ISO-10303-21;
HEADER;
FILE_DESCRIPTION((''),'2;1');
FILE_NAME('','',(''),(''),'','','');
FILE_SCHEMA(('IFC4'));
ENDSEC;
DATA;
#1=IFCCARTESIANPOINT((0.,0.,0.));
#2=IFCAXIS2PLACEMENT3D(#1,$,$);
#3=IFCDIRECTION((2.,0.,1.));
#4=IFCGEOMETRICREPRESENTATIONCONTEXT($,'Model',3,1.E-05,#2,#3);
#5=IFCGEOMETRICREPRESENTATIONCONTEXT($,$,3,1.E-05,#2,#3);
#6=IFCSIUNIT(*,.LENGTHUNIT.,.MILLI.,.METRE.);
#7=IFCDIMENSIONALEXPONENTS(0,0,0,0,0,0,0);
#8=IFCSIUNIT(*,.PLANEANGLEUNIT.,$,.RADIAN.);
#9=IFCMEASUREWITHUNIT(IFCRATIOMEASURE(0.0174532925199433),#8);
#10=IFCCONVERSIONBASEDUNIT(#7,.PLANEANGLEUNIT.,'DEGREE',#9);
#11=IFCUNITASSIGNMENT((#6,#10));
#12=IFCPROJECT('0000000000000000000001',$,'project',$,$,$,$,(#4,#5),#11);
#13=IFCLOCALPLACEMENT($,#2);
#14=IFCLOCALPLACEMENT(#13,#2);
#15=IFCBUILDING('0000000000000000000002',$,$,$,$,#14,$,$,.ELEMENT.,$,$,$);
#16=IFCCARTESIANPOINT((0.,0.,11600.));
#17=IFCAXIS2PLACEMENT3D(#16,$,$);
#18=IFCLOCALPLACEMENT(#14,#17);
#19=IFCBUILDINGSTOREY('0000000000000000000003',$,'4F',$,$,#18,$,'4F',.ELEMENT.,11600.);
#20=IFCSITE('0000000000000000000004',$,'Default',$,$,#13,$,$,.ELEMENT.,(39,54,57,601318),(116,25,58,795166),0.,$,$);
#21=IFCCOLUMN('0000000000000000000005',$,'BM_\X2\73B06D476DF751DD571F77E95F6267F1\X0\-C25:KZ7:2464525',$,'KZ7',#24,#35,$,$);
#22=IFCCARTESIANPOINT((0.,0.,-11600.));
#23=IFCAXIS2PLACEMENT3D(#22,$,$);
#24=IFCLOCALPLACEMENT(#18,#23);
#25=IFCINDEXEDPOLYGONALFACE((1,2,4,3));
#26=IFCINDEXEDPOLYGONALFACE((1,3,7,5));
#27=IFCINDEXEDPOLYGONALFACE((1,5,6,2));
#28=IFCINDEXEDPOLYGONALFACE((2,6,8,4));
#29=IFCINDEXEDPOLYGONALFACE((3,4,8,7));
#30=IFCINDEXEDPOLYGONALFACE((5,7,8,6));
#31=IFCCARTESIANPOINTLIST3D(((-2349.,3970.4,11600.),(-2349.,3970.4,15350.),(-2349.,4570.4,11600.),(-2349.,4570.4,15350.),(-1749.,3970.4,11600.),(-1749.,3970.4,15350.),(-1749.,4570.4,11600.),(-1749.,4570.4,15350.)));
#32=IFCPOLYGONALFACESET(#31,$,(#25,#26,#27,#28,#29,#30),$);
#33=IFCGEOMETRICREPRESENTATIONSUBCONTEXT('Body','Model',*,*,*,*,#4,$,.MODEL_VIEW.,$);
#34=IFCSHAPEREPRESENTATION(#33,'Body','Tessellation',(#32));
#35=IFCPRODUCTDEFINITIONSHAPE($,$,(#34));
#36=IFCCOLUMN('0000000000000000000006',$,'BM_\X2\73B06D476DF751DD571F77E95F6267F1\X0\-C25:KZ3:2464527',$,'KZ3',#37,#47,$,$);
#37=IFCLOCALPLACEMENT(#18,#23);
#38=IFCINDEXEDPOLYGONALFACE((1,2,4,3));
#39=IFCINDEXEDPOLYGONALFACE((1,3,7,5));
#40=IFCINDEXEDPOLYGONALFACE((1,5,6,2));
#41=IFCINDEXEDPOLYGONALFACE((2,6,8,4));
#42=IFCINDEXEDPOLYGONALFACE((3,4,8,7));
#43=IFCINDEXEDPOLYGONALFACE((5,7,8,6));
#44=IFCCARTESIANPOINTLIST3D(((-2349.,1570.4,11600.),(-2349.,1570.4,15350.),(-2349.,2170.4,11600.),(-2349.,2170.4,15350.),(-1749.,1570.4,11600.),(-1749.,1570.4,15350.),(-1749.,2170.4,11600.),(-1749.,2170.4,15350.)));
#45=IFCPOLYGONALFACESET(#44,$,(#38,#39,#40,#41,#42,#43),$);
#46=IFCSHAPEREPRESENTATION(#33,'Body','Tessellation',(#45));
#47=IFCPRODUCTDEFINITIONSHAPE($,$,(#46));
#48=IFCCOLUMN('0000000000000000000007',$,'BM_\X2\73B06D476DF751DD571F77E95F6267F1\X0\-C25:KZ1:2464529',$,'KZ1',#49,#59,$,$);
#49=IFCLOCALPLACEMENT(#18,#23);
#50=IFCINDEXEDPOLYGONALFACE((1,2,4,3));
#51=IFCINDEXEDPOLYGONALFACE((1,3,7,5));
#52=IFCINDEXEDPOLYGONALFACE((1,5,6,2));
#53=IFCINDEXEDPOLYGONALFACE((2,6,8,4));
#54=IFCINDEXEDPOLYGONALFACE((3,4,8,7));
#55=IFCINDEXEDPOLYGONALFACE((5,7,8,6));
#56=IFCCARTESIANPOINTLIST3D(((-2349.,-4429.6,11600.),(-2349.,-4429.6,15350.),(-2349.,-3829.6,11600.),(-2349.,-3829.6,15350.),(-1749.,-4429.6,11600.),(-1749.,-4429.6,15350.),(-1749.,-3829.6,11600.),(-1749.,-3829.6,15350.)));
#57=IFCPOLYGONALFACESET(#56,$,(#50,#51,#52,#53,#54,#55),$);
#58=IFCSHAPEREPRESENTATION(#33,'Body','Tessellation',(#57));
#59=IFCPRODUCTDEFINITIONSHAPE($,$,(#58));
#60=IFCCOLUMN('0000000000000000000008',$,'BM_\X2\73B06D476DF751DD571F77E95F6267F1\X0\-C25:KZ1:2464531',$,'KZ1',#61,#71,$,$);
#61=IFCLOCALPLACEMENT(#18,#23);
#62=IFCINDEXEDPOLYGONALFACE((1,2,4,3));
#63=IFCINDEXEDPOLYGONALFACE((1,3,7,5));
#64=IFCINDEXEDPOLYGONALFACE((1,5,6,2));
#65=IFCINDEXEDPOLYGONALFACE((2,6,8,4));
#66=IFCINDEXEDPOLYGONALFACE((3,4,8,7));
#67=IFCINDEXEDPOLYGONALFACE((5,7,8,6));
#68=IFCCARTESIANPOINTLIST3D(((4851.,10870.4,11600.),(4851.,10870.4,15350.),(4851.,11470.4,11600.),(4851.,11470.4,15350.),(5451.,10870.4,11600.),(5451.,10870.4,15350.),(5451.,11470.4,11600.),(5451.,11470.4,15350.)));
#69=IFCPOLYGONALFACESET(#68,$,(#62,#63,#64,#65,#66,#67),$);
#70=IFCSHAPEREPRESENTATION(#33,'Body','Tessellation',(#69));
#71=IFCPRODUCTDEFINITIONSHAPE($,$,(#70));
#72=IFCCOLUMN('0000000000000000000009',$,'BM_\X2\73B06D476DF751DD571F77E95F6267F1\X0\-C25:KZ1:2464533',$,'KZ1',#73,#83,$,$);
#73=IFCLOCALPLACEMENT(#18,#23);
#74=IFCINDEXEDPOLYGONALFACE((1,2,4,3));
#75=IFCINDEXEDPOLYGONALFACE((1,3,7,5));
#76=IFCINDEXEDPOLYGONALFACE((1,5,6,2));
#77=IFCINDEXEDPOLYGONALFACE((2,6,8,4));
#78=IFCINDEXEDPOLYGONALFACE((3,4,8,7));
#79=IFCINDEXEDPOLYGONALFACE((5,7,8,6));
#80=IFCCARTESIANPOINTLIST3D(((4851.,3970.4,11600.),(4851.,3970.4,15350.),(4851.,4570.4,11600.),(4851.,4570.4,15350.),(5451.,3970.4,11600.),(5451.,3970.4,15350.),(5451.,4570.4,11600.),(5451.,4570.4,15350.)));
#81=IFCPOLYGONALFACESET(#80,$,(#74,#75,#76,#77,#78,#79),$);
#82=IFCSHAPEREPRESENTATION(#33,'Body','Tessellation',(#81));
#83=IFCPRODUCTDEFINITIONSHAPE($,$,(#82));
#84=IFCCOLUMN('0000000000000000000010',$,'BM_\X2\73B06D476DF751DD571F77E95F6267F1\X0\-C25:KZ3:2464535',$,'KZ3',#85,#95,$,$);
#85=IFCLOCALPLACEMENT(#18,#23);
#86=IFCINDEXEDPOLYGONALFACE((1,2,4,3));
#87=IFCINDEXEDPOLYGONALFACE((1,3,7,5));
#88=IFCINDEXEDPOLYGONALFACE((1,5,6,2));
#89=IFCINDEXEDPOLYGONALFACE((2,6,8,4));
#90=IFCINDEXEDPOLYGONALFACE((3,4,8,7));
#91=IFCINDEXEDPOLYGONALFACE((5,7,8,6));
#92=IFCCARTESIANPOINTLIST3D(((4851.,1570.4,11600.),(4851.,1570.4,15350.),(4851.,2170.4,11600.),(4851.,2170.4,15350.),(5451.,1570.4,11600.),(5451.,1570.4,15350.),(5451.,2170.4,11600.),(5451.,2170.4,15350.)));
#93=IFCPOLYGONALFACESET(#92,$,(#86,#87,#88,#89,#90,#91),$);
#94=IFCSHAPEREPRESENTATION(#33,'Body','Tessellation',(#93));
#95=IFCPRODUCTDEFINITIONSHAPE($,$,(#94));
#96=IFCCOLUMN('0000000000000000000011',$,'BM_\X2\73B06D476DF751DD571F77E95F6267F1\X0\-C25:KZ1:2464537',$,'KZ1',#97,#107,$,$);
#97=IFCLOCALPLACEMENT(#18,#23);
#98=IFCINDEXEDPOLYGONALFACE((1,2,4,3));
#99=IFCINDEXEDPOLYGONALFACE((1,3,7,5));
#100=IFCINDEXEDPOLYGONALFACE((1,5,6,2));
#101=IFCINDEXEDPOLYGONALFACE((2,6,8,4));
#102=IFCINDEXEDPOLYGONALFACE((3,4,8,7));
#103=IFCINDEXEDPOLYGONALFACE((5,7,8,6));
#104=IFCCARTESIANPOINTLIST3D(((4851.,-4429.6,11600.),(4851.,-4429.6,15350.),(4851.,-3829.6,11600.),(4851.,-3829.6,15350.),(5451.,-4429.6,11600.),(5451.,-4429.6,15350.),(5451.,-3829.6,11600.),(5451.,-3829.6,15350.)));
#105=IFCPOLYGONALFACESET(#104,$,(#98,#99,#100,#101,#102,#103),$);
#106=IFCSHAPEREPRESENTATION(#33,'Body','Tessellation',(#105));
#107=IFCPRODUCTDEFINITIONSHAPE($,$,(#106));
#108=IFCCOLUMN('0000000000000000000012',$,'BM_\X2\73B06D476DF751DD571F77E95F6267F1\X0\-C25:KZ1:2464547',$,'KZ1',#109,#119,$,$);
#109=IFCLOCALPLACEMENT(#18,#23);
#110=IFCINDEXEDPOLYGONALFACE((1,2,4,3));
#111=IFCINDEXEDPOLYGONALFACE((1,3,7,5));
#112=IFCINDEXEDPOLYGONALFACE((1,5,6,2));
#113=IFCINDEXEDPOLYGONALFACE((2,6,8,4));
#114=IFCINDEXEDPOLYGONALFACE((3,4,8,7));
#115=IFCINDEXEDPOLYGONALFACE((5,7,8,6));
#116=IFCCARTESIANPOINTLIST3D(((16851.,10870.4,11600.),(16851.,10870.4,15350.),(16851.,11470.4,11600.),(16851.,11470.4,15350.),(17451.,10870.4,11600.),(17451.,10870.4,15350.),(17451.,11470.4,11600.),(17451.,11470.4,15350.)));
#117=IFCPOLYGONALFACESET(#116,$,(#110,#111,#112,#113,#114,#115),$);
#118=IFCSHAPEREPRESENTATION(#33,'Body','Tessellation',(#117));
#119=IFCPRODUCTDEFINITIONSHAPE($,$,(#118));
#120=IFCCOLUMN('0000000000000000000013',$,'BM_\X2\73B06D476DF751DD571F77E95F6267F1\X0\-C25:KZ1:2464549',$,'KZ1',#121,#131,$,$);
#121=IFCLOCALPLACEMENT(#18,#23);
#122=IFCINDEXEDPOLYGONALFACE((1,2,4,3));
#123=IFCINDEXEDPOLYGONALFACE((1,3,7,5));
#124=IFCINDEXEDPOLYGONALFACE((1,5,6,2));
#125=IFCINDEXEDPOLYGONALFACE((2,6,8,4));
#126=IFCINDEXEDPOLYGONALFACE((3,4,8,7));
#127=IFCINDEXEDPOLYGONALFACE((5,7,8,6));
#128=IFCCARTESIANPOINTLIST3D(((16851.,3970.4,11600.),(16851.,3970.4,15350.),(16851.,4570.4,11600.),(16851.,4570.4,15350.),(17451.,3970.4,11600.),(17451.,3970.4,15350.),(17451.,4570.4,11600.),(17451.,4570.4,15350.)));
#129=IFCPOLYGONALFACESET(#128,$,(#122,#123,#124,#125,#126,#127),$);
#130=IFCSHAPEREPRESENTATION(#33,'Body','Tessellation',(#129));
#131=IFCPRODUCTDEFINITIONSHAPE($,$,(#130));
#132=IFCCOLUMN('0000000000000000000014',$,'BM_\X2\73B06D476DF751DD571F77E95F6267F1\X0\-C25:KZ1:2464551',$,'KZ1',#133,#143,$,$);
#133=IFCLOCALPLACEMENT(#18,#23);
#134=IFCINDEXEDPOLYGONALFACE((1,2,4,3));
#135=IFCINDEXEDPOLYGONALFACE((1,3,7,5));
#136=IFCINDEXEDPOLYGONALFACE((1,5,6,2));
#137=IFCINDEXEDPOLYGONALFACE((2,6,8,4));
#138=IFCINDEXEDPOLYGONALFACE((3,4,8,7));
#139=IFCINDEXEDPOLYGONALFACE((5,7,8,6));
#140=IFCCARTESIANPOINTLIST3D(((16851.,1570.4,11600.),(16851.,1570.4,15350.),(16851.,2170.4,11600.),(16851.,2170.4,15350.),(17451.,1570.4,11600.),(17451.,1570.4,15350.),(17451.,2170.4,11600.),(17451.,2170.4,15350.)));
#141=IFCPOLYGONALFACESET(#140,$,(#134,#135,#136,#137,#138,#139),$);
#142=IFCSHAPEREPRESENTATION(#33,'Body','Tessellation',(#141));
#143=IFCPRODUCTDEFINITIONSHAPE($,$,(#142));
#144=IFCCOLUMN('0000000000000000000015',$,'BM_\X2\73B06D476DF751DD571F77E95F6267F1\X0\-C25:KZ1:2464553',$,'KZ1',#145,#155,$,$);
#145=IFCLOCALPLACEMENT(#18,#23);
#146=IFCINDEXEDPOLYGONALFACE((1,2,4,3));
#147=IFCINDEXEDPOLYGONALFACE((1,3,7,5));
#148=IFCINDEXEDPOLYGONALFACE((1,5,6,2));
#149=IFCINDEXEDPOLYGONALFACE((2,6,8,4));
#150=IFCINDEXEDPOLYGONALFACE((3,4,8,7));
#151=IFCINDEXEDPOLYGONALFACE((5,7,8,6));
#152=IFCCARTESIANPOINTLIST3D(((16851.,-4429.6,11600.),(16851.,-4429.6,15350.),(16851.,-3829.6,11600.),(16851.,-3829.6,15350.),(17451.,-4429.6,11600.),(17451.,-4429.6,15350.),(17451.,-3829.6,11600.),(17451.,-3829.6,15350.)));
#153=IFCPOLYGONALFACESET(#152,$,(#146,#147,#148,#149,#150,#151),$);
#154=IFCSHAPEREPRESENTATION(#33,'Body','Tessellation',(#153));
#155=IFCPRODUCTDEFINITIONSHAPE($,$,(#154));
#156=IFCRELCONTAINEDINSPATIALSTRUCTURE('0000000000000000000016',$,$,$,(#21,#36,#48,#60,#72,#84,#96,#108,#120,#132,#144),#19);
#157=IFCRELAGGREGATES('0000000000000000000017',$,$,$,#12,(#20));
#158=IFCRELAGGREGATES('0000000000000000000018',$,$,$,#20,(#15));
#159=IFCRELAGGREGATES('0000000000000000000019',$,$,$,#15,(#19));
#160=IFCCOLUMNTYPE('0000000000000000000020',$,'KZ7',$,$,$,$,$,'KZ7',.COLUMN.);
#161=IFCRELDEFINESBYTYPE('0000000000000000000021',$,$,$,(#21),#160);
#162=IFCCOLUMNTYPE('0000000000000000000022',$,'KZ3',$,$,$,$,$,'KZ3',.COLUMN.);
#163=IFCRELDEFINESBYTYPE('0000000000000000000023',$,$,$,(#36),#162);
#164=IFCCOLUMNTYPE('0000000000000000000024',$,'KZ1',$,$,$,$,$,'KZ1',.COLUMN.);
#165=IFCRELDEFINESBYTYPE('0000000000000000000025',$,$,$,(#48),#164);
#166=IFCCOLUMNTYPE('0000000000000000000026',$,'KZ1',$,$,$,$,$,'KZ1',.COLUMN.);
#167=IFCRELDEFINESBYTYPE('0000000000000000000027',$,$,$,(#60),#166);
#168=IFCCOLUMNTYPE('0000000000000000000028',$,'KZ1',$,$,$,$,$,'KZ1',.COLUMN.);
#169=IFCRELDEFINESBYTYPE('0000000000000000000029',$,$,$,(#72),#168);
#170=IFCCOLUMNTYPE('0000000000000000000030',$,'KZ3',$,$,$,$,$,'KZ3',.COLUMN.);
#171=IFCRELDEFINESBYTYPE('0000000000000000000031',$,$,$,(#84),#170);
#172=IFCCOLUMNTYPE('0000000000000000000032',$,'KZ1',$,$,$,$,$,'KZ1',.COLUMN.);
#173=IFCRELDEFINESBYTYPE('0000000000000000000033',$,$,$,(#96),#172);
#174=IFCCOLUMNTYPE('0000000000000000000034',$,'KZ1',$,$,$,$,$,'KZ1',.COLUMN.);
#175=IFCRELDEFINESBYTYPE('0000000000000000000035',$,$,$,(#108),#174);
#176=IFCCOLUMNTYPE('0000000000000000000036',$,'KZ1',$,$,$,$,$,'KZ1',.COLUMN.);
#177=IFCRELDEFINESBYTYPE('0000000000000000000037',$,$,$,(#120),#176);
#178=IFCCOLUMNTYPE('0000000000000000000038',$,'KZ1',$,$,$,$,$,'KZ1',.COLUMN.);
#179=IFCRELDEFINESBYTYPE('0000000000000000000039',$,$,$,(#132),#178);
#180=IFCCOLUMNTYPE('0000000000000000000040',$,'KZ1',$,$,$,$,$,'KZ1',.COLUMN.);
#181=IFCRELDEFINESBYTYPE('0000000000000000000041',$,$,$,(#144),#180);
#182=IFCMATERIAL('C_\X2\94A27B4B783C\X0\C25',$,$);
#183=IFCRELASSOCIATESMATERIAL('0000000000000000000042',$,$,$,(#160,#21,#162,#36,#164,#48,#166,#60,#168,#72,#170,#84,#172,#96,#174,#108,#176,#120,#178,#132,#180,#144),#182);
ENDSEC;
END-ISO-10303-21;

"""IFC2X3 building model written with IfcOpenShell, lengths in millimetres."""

from ifc_helpers import new_model, entity, si_unit, converted_unit, direction, frame, frame_2d, origin, origin_2d_with_axis, place, context, subcontext, project, spatial, rectangle, extrude, source, transform, mapped, material, type_object, type_shapes, element, save


model = new_model("IFC2X3")

# Units and contexts
model_context = context("Model", 3, precision=1e-05, world=origin(), true_north=direction((2.0, 0.0, 1.0)))
context_of_model = context(None, 3, precision=1e-05, world=origin(), true_north=direction((2.0, 0.0, 1.0)))
body_context = subcontext(model_context, "Body", "Model", "MODEL_VIEW")
ifc_project = project(units=[si_unit("LENGTHUNIT", "METRE", prefix="MILLI"), converted_unit("PLANEANGLEUNIT", "DEGREE", entity("IfcRatioMeasure", 0.0174532925199433), si_unit("PLANEANGLEUNIT", "RADIAN"), dimensions=[0, 0, 0, 0, 0, 0, 0])], contexts=[model_context, context_of_model])

# Site, building, storey
site_placement = place(None, origin())
site = spatial("IfcSite", under=ifc_project, at=site_placement, Name="Default", CompositionType="ELEMENT", RefLatitude=(39, 54, 57, 601318), RefLongitude=(116, 25, 58, 795166), RefElevation=0.0)
building_placement = place(site_placement, origin())
building = spatial("IfcBuilding", under=site, at=building_placement, CompositionType="ELEMENT")
storey_placement = place(building_placement, frame((0.0, 0.0, 11600.0)))
storey = spatial("IfcBuildingStorey", under=building, at=storey_placement, Name="4F", LongName="4F", CompositionType="ELEMENT", Elevation=11600.0)

# Columns
ifc_material = material(Name="C_钢筋砼C25")
column_type_1 = type_object("IfcColumnType", Name="KZ7", ElementType="KZ7", PredefinedType="COLUMN", material=ifc_material)
shared_shape_1 = source(origin(), body_context, "Body", "SweptSolid", [
    extrude(rectangle(XDim=600.0, YDim=600.0, at=origin_2d_with_axis()), frame((-2049.0, 4270.4, 11600.0), z_axis=(0.0, 0.0, 1.0), x_axis=(-1.0, 0.0, 0.0)), (0.0, 0.0, 1.0), 3750.0),
])
type_shapes(column_type_1, [shared_shape_1])
column_1_placement = place(storey_placement, frame((0.0, 0.0, -11600.0)))
element("IfcColumn", 1, at=column_1_placement, inside=storey, type_object=column_type_1, material=ifc_material, Name="BM_现浇混凝土矩形柱-C25:KZ7:2464525", ObjectType="KZ7", context=body_context, shape_type="MappedRepresentation", body=[
    mapped(shared_shape_1, transform((0.0, 0.0, 0.0), scale=1.0)),
])
column_type_2 = type_object("IfcColumnType", Name="KZ3", ElementType="KZ3", PredefinedType="COLUMN", material=ifc_material)
shared_shape_2 = source(origin(), body_context, "Body", "SweptSolid", [
    extrude(rectangle(XDim=600.0, YDim=600.0, at=origin_2d_with_axis()), frame((-2049.0, 1870.4, 11600.0), z_axis=(0.0, 0.0, 1.0), x_axis=(-1.0, 0.0, 0.0)), (0.0, 0.0, 1.0), 3750.0),
])
type_shapes(column_type_2, [shared_shape_2])
column_2_placement = place(storey_placement, frame((0.0, 0.0, -11600.0)))
element("IfcColumn", 2, at=column_2_placement, inside=storey, type_object=column_type_2, material=ifc_material, Name="BM_现浇混凝土矩形柱-C25:KZ3:2464527", ObjectType="KZ3", context=body_context, shape_type="MappedRepresentation", body=[
    mapped(shared_shape_2, transform((0.0, 0.0, 0.0), scale=1.0)),
])
column_type_3 = type_object("IfcColumnType", Name="KZ1", ElementType="KZ1", PredefinedType="COLUMN", material=ifc_material)
shared_shape_3 = source(origin(), body_context, "Body", "SweptSolid", [
    extrude(rectangle(XDim=600.0, YDim=600.0, at=origin_2d_with_axis()), frame((-2049.0, -4129.6, 11600.0), z_axis=(0.0, 0.0, 1.0), x_axis=(-1.0, 0.0, 0.0)), (0.0, 0.0, 1.0), 3750.0),
])
type_shapes(column_type_3, [shared_shape_3])
column_3_placement = place(storey_placement, frame((0.0, 0.0, -11600.0)))
element("IfcColumn", 3, at=column_3_placement, inside=storey, type_object=column_type_3, material=ifc_material, Name="BM_现浇混凝土矩形柱-C25:KZ1:2464529", ObjectType="KZ1", context=body_context, shape_type="MappedRepresentation", body=[
    mapped(shared_shape_3, transform((0.0, 0.0, 0.0), scale=1.0)),
])
column_type_4 = type_object("IfcColumnType", Name="KZ1", ElementType="KZ1", PredefinedType="COLUMN", material=ifc_material)
shared_shape_4 = source(origin(), body_context, "Body", "SweptSolid", [
    extrude(rectangle(XDim=600.0, YDim=600.0, at=frame_2d((0.0, 0.0), x_axis=(1.0, 0.0))), frame((5151.0, 11170.4, 11600.0), z_axis=(0.0, 0.0, 1.0), x_axis=(-1.0, 0.0, 0.0)), (0.0, 0.0, 1.0), 3750.0),
])
type_shapes(column_type_4, [shared_shape_4])
column_4_placement = place(storey_placement, frame((0.0, 0.0, -11600.0)))
element("IfcColumn", 4, at=column_4_placement, inside=storey, type_object=column_type_4, material=ifc_material, Name="BM_现浇混凝土矩形柱-C25:KZ1:2464531", ObjectType="KZ1", context=body_context, shape_type="MappedRepresentation", body=[
    mapped(shared_shape_4, transform((0.0, 0.0, 0.0), scale=1.0)),
])
column_type_5 = type_object("IfcColumnType", Name="KZ1", ElementType="KZ1", PredefinedType="COLUMN", material=ifc_material)
shared_shape_5 = source(origin(), body_context, "Body", "SweptSolid", [
    extrude(rectangle(XDim=600.0, YDim=600.0, at=origin_2d_with_axis()), frame((5151.0, 4270.4, 11600.0), z_axis=(0.0, 0.0, 1.0), x_axis=(-1.0, 0.0, 0.0)), (0.0, 0.0, 1.0), 3750.0),
])
type_shapes(column_type_5, [shared_shape_5])
column_5_placement = place(storey_placement, frame((0.0, 0.0, -11600.0)))
element("IfcColumn", 5, at=column_5_placement, inside=storey, type_object=column_type_5, material=ifc_material, Name="BM_现浇混凝土矩形柱-C25:KZ1:2464533", ObjectType="KZ1", context=body_context, shape_type="MappedRepresentation", body=[
    mapped(shared_shape_5, transform((0.0, 0.0, 0.0), scale=1.0)),
])
column_type_6 = type_object("IfcColumnType", Name="KZ3", ElementType="KZ3", PredefinedType="COLUMN", material=ifc_material)
shared_shape_6 = source(origin(), body_context, "Body", "SweptSolid", [
    extrude(rectangle(XDim=600.0, YDim=600.0, at=origin_2d_with_axis()), frame((5151.0, 1870.4, 11600.0), z_axis=(0.0, 0.0, 1.0), x_axis=(-1.0, 0.0, 0.0)), (0.0, 0.0, 1.0), 3750.0),
])
type_shapes(column_type_6, [shared_shape_6])
column_6_placement = place(storey_placement, frame((0.0, 0.0, -11600.0)))
element("IfcColumn", 6, at=column_6_placement, inside=storey, type_object=column_type_6, material=ifc_material, Name="BM_现浇混凝土矩形柱-C25:KZ3:2464535", ObjectType="KZ3", context=body_context, shape_type="MappedRepresentation", body=[
    mapped(shared_shape_6, transform((0.0, 0.0, 0.0), scale=1.0)),
])
column_type_7 = type_object("IfcColumnType", Name="KZ1", ElementType="KZ1", PredefinedType="COLUMN", material=ifc_material)
shared_shape_7 = source(origin(), body_context, "Body", "SweptSolid", [
    extrude(rectangle(XDim=600.0, YDim=600.0, at=origin_2d_with_axis()), frame((5151.0, -4129.6, 11600.0), z_axis=(0.0, 0.0, 1.0), x_axis=(-1.0, 0.0, 0.0)), (0.0, 0.0, 1.0), 3750.0),
])
type_shapes(column_type_7, [shared_shape_7])
column_7_placement = place(storey_placement, frame((0.0, 0.0, -11600.0)))
element("IfcColumn", 7, at=column_7_placement, inside=storey, type_object=column_type_7, material=ifc_material, Name="BM_现浇混凝土矩形柱-C25:KZ1:2464537", ObjectType="KZ1", context=body_context, shape_type="MappedRepresentation", body=[
    mapped(shared_shape_7, transform((0.0, 0.0, 0.0), scale=1.0)),
])
column_type_8 = type_object("IfcColumnType", Name="KZ1", ElementType="KZ1", PredefinedType="COLUMN", material=ifc_material)
shared_shape_8 = source(origin(), body_context, "Body", "SweptSolid", [
    extrude(rectangle(XDim=600.0, YDim=600.0, at=frame_2d((0.0, 0.0), x_axis=(1.0, 0.0))), frame((17151.0, 11170.4, 11600.0), z_axis=(0.0, 0.0, 1.0), x_axis=(-1.0, 0.0, 0.0)), (0.0, 0.0, 1.0), 3750.0),
])
type_shapes(column_type_8, [shared_shape_8])
column_8_placement = place(storey_placement, frame((0.0, 0.0, -11600.0)))
element("IfcColumn", 8, at=column_8_placement, inside=storey, type_object=column_type_8, material=ifc_material, Name="BM_现浇混凝土矩形柱-C25:KZ1:2464547", ObjectType="KZ1", context=body_context, shape_type="MappedRepresentation", body=[
    mapped(shared_shape_8, transform((0.0, 0.0, 0.0), scale=1.0)),
])
column_type_9 = type_object("IfcColumnType", Name="KZ1", ElementType="KZ1", PredefinedType="COLUMN", material=ifc_material)
shared_shape_9 = source(origin(), body_context, "Body", "SweptSolid", [
    extrude(rectangle(XDim=600.0, YDim=600.0, at=frame_2d((0.0, 0.0), x_axis=(1.0, 0.0))), frame((17151.0, 4270.4, 11600.0), z_axis=(0.0, 0.0, 1.0), x_axis=(-1.0, 0.0, 0.0)), (0.0, 0.0, 1.0), 3750.0),
])
type_shapes(column_type_9, [shared_shape_9])
column_9_placement = place(storey_placement, frame((0.0, 0.0, -11600.0)))
element("IfcColumn", 9, at=column_9_placement, inside=storey, type_object=column_type_9, material=ifc_material, Name="BM_现浇混凝土矩形柱-C25:KZ1:2464549", ObjectType="KZ1", context=body_context, shape_type="MappedRepresentation", body=[
    mapped(shared_shape_9, transform((0.0, 0.0, 0.0), scale=1.0)),
])
column_type_10 = type_object("IfcColumnType", Name="KZ1", ElementType="KZ1", PredefinedType="COLUMN", material=ifc_material)
shared_shape_10 = source(origin(), body_context, "Body", "SweptSolid", [
    extrude(rectangle(XDim=600.0, YDim=600.0, at=frame_2d((0.0, 0.0), x_axis=(1.0, 0.0))), frame((17151.0, 1870.4, 11600.0), z_axis=(0.0, 0.0, 1.0), x_axis=(-1.0, 0.0, 0.0)), (0.0, 0.0, 1.0), 3750.0),
])
type_shapes(column_type_10, [shared_shape_10])
column_10_placement = place(storey_placement, frame((0.0, 0.0, -11600.0)))
element("IfcColumn", 10, at=column_10_placement, inside=storey, type_object=column_type_10, material=ifc_material, Name="BM_现浇混凝土矩形柱-C25:KZ1:2464551", ObjectType="KZ1", context=body_context, shape_type="MappedRepresentation", body=[
    mapped(shared_shape_10, transform((0.0, 0.0, 0.0), scale=1.0)),
])
column_type_11 = type_object("IfcColumnType", Name="KZ1", ElementType="KZ1", PredefinedType="COLUMN", material=ifc_material)
shared_shape_11 = source(origin(), body_context, "Body", "SweptSolid", [
    extrude(rectangle(XDim=600.0, YDim=600.0, at=frame_2d((0.0, 0.0), x_axis=(1.0, 0.0))), frame((17151.0, -4129.6, 11600.0), z_axis=(0.0, 0.0, 1.0), x_axis=(-1.0, 0.0, 0.0)), (0.0, 0.0, 1.0), 3750.0),
])
type_shapes(column_type_11, [shared_shape_11])
column_11_placement = place(storey_placement, frame((0.0, 0.0, -11600.0)))
element("IfcColumn", 11, at=column_11_placement, inside=storey, type_object=column_type_11, material=ifc_material, Name="BM_现浇混凝土矩形柱-C25:KZ1:2464553", ObjectType="KZ1", context=body_context, shape_type="MappedRepresentation", body=[
    mapped(shared_shape_11, transform((0.0, 0.0, 0.0), scale=1.0)),
])

save(model, "model.ifc")
